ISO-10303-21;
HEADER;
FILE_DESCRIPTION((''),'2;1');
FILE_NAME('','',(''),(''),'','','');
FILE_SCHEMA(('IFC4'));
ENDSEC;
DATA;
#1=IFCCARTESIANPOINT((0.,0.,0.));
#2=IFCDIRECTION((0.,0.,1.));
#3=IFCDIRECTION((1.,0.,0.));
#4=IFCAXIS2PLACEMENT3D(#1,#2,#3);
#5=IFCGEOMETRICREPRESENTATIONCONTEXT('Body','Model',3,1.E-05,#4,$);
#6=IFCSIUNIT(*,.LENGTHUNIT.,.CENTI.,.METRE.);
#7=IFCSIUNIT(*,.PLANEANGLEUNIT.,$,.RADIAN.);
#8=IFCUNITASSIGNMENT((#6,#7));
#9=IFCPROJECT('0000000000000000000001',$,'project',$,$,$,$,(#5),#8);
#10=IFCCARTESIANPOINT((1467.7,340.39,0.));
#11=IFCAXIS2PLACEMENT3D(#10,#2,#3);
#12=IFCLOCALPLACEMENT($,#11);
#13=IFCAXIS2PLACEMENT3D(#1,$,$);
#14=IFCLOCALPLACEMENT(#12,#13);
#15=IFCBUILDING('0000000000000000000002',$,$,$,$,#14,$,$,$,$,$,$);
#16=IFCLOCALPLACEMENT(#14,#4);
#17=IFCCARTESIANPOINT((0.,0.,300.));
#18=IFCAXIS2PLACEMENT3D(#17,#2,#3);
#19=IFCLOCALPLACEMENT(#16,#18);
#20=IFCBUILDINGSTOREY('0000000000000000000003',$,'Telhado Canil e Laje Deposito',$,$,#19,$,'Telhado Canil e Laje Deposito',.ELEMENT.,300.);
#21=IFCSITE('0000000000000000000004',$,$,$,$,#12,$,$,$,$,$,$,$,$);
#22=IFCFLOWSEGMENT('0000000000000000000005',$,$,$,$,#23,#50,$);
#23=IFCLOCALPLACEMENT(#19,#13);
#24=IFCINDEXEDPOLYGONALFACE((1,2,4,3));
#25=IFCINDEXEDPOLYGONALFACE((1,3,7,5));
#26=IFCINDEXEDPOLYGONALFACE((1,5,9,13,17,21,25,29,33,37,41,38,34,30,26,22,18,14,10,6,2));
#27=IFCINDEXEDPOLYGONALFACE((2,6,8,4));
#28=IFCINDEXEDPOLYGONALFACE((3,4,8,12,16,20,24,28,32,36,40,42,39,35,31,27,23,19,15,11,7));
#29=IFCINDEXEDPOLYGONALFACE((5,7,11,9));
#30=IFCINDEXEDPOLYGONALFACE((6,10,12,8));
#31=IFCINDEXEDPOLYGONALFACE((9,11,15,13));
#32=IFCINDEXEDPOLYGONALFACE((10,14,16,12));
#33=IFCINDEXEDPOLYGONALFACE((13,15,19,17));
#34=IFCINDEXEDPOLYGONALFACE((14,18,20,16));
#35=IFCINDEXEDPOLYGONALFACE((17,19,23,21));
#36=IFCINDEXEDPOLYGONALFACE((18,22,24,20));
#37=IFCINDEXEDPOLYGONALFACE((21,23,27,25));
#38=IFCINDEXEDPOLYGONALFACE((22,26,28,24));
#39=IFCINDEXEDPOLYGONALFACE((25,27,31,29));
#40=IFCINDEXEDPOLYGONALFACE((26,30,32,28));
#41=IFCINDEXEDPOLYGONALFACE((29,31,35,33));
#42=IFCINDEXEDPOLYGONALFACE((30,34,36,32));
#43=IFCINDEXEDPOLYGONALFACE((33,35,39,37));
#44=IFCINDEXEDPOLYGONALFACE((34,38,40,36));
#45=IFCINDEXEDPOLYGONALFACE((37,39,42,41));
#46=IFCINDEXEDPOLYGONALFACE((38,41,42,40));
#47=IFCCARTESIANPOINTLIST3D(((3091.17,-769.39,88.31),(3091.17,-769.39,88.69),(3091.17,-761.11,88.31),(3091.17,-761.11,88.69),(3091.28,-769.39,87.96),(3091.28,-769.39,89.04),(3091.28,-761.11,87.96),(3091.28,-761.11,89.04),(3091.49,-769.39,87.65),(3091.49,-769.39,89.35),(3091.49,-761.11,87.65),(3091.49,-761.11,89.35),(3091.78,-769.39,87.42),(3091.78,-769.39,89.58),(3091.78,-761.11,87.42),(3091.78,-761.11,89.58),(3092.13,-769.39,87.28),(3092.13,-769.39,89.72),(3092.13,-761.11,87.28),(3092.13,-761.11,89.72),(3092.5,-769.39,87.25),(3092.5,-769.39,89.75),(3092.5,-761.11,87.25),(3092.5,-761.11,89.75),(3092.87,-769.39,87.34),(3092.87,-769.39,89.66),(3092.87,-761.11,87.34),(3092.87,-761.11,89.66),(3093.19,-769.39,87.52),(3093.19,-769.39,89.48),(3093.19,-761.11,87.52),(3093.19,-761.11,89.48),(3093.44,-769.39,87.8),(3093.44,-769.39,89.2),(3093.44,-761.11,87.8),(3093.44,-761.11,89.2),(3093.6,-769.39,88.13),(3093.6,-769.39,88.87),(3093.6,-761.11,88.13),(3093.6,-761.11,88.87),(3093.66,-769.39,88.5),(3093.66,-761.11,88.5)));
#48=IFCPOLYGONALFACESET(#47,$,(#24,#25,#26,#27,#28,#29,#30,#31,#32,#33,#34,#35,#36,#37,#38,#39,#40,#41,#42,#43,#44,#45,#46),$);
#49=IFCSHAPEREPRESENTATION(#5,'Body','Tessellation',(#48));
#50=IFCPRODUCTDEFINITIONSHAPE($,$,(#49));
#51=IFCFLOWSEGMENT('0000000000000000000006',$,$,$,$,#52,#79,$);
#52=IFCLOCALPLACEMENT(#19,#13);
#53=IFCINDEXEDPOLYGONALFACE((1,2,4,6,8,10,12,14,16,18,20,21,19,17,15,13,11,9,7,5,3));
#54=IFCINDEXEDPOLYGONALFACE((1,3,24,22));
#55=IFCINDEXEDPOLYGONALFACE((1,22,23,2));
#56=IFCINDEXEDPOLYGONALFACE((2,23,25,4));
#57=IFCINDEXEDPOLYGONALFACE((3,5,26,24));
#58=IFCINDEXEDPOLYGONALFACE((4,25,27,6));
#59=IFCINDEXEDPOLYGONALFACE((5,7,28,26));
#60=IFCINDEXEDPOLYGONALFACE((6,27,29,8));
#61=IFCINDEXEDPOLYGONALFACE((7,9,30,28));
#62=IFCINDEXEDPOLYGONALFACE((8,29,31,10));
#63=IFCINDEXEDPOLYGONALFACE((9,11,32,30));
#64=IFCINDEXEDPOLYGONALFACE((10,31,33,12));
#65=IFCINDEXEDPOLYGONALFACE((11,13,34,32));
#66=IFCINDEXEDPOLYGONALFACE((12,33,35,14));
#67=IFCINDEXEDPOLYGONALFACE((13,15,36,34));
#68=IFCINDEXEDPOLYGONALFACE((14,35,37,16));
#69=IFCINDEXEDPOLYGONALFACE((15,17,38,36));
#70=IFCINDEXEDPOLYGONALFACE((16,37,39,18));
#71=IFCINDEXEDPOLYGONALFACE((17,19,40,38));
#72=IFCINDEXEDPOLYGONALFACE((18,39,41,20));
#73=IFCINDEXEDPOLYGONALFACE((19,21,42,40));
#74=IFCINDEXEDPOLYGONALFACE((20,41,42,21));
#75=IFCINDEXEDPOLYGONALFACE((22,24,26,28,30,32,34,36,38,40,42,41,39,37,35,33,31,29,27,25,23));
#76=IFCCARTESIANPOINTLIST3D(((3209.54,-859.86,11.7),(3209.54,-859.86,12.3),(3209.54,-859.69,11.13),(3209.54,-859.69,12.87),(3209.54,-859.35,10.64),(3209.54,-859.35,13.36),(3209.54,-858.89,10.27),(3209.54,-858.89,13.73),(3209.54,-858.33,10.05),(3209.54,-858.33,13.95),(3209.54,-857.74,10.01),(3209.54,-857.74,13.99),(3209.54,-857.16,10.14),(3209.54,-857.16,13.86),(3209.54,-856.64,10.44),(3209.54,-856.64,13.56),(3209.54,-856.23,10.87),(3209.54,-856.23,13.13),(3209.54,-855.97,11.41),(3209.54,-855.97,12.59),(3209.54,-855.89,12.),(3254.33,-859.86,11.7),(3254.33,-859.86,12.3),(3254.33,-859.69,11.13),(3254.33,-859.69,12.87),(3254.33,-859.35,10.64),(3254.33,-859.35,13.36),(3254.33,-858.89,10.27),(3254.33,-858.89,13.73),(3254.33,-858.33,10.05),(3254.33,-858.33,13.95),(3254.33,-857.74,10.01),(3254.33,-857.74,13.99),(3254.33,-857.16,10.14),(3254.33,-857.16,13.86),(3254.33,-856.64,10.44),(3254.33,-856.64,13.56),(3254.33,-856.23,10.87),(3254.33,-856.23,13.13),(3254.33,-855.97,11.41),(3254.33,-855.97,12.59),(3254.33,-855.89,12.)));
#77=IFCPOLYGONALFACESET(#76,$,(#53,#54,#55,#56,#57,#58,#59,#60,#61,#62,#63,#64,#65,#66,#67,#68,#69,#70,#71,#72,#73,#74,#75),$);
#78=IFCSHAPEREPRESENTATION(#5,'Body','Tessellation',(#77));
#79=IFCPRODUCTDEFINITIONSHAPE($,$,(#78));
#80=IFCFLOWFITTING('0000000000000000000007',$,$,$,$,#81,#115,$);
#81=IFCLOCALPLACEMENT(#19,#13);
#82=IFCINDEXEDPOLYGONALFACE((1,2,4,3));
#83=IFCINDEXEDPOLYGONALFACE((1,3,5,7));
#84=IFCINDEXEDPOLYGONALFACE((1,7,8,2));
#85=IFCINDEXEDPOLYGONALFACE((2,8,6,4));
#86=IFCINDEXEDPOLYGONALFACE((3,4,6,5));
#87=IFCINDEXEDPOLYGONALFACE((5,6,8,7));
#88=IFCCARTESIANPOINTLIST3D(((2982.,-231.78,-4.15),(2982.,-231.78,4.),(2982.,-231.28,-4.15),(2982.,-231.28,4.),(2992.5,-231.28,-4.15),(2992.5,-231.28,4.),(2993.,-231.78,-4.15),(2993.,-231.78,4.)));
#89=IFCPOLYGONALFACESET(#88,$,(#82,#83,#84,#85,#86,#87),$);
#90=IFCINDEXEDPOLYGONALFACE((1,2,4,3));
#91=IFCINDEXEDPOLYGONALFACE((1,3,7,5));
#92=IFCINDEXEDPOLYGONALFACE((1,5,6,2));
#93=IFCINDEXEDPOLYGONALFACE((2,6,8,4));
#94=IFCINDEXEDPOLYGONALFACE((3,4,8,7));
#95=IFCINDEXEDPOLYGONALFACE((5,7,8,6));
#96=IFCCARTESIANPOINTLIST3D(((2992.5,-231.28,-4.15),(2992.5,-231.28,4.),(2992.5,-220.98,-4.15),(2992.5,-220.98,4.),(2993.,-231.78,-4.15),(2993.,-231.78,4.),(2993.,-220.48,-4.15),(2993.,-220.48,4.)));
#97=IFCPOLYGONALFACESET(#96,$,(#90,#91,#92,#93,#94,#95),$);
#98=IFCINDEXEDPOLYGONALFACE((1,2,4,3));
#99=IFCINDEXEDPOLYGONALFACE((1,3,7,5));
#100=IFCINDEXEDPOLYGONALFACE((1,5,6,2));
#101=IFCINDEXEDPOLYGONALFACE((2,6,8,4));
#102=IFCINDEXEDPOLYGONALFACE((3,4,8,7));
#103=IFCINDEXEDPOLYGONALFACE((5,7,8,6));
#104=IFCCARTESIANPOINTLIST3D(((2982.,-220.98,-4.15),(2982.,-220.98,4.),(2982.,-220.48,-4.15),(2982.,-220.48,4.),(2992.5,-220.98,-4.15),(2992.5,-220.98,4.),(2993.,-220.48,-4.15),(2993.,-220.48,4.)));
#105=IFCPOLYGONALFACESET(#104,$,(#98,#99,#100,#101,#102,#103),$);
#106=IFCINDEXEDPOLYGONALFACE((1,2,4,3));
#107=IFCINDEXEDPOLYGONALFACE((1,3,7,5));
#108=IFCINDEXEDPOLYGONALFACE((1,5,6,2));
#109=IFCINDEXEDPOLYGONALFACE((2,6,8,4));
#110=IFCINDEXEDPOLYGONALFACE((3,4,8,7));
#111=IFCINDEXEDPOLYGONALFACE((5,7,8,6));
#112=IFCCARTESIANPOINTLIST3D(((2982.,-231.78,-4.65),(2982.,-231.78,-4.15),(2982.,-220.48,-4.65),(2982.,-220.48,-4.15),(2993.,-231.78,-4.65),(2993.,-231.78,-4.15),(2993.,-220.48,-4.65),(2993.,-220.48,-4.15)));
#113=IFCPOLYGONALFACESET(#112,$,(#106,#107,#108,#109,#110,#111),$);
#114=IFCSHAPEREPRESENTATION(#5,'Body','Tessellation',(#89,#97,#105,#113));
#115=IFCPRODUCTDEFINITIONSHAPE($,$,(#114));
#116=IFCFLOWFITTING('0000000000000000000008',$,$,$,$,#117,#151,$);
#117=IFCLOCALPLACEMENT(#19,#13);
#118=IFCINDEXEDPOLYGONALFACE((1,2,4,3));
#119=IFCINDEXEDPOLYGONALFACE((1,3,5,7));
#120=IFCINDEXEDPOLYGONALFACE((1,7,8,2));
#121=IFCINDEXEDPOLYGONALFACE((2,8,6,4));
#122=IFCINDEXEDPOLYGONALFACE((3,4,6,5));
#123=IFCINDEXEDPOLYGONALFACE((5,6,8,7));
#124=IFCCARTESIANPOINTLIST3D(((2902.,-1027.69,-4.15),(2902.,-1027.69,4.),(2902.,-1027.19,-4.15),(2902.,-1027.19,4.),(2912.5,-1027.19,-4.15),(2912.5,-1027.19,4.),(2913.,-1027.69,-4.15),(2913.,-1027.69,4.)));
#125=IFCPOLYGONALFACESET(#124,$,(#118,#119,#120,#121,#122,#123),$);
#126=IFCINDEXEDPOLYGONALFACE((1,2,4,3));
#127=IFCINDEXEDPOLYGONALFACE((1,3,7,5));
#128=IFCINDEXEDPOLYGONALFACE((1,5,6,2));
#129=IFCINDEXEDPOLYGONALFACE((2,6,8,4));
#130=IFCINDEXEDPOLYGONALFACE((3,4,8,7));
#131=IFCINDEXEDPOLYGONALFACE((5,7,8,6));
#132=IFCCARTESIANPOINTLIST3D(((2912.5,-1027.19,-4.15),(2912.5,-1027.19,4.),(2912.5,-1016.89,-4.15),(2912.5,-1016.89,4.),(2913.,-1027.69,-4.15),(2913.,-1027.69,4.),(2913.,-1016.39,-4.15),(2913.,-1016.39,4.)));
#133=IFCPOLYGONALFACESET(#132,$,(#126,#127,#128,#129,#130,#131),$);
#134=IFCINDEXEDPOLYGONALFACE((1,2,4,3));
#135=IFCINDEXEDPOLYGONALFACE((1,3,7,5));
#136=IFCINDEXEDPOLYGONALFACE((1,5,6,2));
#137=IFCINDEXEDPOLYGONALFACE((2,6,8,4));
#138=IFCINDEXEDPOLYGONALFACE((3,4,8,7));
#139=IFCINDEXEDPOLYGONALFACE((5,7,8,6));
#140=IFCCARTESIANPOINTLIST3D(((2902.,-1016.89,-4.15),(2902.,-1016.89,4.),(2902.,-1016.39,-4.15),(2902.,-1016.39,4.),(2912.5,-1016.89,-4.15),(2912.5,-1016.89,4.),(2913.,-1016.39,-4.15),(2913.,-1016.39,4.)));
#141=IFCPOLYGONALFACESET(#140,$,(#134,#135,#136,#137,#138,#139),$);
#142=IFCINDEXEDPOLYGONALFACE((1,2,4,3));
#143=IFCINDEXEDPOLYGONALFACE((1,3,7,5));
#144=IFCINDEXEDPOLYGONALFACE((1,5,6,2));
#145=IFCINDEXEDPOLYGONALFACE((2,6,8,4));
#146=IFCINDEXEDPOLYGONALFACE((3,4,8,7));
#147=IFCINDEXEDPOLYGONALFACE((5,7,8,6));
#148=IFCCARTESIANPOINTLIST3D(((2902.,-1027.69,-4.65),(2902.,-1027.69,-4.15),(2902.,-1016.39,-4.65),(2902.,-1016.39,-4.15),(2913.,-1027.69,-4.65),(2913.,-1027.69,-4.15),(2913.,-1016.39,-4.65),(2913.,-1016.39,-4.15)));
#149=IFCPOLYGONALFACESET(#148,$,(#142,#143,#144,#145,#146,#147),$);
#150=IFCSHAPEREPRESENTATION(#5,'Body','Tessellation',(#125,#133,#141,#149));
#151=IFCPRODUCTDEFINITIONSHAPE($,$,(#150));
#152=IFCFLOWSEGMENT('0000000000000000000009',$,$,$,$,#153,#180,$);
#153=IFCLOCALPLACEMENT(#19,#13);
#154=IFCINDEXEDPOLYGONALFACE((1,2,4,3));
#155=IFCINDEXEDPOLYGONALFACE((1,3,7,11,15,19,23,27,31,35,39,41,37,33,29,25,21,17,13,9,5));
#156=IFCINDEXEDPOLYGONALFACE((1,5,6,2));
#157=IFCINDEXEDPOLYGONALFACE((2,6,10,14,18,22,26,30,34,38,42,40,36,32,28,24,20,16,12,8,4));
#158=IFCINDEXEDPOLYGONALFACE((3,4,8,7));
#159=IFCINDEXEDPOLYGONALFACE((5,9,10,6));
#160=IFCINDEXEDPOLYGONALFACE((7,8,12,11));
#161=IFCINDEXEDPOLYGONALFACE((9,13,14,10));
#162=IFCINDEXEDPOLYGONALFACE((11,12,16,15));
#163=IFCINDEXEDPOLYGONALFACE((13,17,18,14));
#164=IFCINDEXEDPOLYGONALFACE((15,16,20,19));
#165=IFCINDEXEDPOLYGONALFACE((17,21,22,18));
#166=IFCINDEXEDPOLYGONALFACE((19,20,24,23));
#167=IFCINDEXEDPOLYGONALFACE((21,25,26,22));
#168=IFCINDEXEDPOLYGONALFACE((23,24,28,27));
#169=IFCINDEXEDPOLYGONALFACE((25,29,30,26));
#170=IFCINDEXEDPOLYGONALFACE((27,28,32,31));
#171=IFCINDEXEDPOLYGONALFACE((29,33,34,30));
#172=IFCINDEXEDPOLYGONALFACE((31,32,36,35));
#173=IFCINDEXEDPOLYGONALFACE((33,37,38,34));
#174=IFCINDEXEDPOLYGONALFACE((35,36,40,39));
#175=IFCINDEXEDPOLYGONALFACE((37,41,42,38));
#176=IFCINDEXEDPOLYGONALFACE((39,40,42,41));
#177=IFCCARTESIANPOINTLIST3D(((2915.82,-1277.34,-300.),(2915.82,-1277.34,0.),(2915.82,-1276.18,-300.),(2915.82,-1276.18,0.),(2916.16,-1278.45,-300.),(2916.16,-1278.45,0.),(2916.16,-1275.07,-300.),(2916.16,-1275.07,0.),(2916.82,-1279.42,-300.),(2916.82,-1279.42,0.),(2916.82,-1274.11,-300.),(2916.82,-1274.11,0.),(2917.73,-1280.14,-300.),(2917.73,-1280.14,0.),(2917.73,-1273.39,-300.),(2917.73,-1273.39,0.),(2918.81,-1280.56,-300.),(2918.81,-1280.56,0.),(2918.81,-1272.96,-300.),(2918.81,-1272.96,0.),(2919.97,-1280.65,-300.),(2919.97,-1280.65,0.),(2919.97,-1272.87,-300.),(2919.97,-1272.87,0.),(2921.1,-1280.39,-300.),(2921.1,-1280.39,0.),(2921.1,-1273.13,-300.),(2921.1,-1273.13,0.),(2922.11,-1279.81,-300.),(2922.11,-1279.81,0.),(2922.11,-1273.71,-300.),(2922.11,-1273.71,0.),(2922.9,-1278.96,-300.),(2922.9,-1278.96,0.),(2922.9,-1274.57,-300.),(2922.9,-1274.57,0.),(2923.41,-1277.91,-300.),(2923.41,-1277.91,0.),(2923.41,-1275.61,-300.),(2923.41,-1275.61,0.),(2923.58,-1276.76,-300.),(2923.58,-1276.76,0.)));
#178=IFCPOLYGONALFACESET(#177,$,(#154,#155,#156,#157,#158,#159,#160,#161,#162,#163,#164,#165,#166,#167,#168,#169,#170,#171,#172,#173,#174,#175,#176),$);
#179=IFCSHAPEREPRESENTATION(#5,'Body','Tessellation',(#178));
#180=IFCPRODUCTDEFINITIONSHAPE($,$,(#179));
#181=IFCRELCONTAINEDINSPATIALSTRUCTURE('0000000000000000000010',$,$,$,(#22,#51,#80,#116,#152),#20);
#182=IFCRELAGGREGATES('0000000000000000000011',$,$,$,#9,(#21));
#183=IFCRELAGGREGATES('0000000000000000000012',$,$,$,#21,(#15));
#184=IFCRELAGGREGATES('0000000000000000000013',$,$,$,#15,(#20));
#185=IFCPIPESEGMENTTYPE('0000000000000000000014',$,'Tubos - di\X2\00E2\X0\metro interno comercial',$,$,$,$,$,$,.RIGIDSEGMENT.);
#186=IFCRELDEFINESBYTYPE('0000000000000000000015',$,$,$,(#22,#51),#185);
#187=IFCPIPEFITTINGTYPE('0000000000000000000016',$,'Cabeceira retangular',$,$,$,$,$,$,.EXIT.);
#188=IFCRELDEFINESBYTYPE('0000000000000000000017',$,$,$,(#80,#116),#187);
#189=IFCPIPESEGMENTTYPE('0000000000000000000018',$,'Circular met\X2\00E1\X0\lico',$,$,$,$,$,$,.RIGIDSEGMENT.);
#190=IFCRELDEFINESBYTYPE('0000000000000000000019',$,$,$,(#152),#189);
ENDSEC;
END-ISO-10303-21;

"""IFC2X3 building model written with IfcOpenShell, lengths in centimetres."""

from ifc_helpers import new_model, si_unit, frame, origin, origin_with_axes, origin_2d_with_axis, place, context, project, spatial, polyline, circle, outline, extrude, type_object, element, save


model = new_model("IFC2X3")

# Units and contexts
model_context = context("Model", 3, precision=1e-05, world=origin_with_axes(), identifier="Body")
ifc_project = project(units=[si_unit("LENGTHUNIT", "METRE", prefix="CENTI"), si_unit("PLANEANGLEUNIT", "RADIAN")], contexts=[model_context])

# Site, building, storey
site_placement = place(None, frame((1467.7, 340.39, 0.0), z_axis=(0.0, 0.0, 1.0), x_axis=(1.0, 0.0, 0.0)))
site = spatial("IfcSite", under=ifc_project, at=site_placement)
building_placement = place(site_placement, origin())
building = spatial("IfcBuilding", under=site, at=building_placement)
placement = place(building_placement, origin_with_axes())
storey_placement = place(placement, frame((0.0, 0.0, 300.0), z_axis=(0.0, 0.0, 1.0), x_axis=(1.0, 0.0, 0.0)))
storey = spatial("IfcBuildingStorey", under=building, at=storey_placement, Name="Telhado Canil e Laje Deposito", LongName="Telhado Canil e Laje Deposito", CompositionType="ELEMENT", Elevation=300.0)

# Flow segments
pipe_segment_type_1 = type_object("IfcPipeSegmentType", Name="Tubos - diâmetro interno comercial", PredefinedType="RIGIDSEGMENT")
flow_segment_1_placement = place(storey_placement, frame((3092.41, -765.25, 89.75), z_axis=(0.0, 0.0, 1.0), x_axis=(1.0, 0.0, 0.0)))
element("IfcFlowSegment", 1, at=flow_segment_1_placement, inside=storey, type_object=pipe_segment_type_1, context=model_context, shape_type="SolidModel", body=[
    extrude(circle(Radius=1.25, at=origin_2d_with_axis()), frame((0.0, 4.14, -1.25), z_axis=(0.0, -1.0, 0.0), x_axis=(1.0, 0.0, 0.0)), (0.0, 0.0, 1.0), 8.28),
])
flow_segment_2_placement = place(storey_placement, frame((3231.93, -857.89, 14.0), z_axis=(0.0, 0.0, 1.0), x_axis=(1.0, 0.0, 0.0)))
element("IfcFlowSegment", 2, at=flow_segment_2_placement, inside=storey, type_object=pipe_segment_type_1, context=model_context, shape_type="SolidModel", body=[
    extrude(circle(Radius=2.0, at=origin_2d_with_axis()), frame((-22.39, 0.0, -2.0), z_axis=(1.0, 0.0, 0.0), x_axis=(0.0, 1.0, 0.0)), (0.0, 0.0, 1.0), 44.78),
])

# Flow fittings
pipe_fitting_type = type_object("IfcPipeFittingType", Name="Cabeceira retangular", PredefinedType="EXIT")
for number, where, z_axis, x_axis in (
    (3, (2987.5, -226.13, 4.0), (0.0, 0.0, 1.0), (1.0, 0.0, 0.0)),
    (4, (2907.5, -1022.04, 4.0), (0.0, 0.0, 1.0), (1.0, 0.0, 0.0)),
):
    element("IfcFlowFitting", number, at=place(storey_placement, frame(where, z_axis=z_axis, x_axis=x_axis)), inside=storey, type_object=pipe_fitting_type, context=model_context, shape_type="SolidModel", body=[
        extrude(outline(polyline([(0.0, 0.0), (11.0, 0.0), (10.5, 0.5), (0.0, 0.5), (0.0, 0.0)])), frame((-5.5, -5.65, -8.15), z_axis=(0.0, 0.0, 1.0), x_axis=(1.0, 0.0, 0.0)), (0.0, 0.0, 1.0), 8.15),
        extrude(outline(polyline([(0.0, 0.0), (11.3, 0.0), (10.8, 0.5), (0.5, 0.5), (0.0, 0.0)])), frame((5.5, -5.65, -8.15), z_axis=(0.0, 0.0, 1.0), x_axis=(0.0, 1.0, 0.0)), (0.0, 0.0, 1.0), 8.15),
        extrude(outline(polyline([(0.0, 0.0), (11.0, 0.0), (11.0, 0.5), (0.5, 0.5), (0.0, 0.0)])), frame((5.5, 5.65, -8.15), z_axis=(0.0, 0.0, 1.0), x_axis=(-1.0, 0.0, 0.0)), (0.0, 0.0, 1.0), 8.15),
        extrude(outline(polyline([(0.0, 0.0), (11.0, 0.0), (11.0, 11.3), (0.0, 11.3), (0.0, 0.0)])), frame((-5.5, -5.65, -8.15), z_axis=(0.0, 0.0, 1.0), x_axis=(1.0, 0.0, 0.0)), (0.0, 0.0, -1.0), 0.5),
    ])

# Flow segment
pipe_segment_type_2 = type_object("IfcPipeSegmentType", Name="Circular metálico", PredefinedType="RIGIDSEGMENT")
flow_segment_3_placement = place(storey_placement, frame((2919.68, -1276.76, 0.0), z_axis=(0.0, 0.0, 1.0), x_axis=(1.0, 0.0, 0.0)))
element("IfcFlowSegment", 5, at=flow_segment_3_placement, inside=storey, type_object=pipe_segment_type_2, context=model_context, shape_type="SolidModel", body=[
    extrude(circle(Radius=3.9, at=origin_2d_with_axis()), frame((0.0, 0.0, 0.0), z_axis=(0.0, 0.0, -1.0), x_axis=(1.0, 0.0, 0.0)), (0.0, 0.0, 1.0), 300.0),
])

save(model, "model.ifc")
